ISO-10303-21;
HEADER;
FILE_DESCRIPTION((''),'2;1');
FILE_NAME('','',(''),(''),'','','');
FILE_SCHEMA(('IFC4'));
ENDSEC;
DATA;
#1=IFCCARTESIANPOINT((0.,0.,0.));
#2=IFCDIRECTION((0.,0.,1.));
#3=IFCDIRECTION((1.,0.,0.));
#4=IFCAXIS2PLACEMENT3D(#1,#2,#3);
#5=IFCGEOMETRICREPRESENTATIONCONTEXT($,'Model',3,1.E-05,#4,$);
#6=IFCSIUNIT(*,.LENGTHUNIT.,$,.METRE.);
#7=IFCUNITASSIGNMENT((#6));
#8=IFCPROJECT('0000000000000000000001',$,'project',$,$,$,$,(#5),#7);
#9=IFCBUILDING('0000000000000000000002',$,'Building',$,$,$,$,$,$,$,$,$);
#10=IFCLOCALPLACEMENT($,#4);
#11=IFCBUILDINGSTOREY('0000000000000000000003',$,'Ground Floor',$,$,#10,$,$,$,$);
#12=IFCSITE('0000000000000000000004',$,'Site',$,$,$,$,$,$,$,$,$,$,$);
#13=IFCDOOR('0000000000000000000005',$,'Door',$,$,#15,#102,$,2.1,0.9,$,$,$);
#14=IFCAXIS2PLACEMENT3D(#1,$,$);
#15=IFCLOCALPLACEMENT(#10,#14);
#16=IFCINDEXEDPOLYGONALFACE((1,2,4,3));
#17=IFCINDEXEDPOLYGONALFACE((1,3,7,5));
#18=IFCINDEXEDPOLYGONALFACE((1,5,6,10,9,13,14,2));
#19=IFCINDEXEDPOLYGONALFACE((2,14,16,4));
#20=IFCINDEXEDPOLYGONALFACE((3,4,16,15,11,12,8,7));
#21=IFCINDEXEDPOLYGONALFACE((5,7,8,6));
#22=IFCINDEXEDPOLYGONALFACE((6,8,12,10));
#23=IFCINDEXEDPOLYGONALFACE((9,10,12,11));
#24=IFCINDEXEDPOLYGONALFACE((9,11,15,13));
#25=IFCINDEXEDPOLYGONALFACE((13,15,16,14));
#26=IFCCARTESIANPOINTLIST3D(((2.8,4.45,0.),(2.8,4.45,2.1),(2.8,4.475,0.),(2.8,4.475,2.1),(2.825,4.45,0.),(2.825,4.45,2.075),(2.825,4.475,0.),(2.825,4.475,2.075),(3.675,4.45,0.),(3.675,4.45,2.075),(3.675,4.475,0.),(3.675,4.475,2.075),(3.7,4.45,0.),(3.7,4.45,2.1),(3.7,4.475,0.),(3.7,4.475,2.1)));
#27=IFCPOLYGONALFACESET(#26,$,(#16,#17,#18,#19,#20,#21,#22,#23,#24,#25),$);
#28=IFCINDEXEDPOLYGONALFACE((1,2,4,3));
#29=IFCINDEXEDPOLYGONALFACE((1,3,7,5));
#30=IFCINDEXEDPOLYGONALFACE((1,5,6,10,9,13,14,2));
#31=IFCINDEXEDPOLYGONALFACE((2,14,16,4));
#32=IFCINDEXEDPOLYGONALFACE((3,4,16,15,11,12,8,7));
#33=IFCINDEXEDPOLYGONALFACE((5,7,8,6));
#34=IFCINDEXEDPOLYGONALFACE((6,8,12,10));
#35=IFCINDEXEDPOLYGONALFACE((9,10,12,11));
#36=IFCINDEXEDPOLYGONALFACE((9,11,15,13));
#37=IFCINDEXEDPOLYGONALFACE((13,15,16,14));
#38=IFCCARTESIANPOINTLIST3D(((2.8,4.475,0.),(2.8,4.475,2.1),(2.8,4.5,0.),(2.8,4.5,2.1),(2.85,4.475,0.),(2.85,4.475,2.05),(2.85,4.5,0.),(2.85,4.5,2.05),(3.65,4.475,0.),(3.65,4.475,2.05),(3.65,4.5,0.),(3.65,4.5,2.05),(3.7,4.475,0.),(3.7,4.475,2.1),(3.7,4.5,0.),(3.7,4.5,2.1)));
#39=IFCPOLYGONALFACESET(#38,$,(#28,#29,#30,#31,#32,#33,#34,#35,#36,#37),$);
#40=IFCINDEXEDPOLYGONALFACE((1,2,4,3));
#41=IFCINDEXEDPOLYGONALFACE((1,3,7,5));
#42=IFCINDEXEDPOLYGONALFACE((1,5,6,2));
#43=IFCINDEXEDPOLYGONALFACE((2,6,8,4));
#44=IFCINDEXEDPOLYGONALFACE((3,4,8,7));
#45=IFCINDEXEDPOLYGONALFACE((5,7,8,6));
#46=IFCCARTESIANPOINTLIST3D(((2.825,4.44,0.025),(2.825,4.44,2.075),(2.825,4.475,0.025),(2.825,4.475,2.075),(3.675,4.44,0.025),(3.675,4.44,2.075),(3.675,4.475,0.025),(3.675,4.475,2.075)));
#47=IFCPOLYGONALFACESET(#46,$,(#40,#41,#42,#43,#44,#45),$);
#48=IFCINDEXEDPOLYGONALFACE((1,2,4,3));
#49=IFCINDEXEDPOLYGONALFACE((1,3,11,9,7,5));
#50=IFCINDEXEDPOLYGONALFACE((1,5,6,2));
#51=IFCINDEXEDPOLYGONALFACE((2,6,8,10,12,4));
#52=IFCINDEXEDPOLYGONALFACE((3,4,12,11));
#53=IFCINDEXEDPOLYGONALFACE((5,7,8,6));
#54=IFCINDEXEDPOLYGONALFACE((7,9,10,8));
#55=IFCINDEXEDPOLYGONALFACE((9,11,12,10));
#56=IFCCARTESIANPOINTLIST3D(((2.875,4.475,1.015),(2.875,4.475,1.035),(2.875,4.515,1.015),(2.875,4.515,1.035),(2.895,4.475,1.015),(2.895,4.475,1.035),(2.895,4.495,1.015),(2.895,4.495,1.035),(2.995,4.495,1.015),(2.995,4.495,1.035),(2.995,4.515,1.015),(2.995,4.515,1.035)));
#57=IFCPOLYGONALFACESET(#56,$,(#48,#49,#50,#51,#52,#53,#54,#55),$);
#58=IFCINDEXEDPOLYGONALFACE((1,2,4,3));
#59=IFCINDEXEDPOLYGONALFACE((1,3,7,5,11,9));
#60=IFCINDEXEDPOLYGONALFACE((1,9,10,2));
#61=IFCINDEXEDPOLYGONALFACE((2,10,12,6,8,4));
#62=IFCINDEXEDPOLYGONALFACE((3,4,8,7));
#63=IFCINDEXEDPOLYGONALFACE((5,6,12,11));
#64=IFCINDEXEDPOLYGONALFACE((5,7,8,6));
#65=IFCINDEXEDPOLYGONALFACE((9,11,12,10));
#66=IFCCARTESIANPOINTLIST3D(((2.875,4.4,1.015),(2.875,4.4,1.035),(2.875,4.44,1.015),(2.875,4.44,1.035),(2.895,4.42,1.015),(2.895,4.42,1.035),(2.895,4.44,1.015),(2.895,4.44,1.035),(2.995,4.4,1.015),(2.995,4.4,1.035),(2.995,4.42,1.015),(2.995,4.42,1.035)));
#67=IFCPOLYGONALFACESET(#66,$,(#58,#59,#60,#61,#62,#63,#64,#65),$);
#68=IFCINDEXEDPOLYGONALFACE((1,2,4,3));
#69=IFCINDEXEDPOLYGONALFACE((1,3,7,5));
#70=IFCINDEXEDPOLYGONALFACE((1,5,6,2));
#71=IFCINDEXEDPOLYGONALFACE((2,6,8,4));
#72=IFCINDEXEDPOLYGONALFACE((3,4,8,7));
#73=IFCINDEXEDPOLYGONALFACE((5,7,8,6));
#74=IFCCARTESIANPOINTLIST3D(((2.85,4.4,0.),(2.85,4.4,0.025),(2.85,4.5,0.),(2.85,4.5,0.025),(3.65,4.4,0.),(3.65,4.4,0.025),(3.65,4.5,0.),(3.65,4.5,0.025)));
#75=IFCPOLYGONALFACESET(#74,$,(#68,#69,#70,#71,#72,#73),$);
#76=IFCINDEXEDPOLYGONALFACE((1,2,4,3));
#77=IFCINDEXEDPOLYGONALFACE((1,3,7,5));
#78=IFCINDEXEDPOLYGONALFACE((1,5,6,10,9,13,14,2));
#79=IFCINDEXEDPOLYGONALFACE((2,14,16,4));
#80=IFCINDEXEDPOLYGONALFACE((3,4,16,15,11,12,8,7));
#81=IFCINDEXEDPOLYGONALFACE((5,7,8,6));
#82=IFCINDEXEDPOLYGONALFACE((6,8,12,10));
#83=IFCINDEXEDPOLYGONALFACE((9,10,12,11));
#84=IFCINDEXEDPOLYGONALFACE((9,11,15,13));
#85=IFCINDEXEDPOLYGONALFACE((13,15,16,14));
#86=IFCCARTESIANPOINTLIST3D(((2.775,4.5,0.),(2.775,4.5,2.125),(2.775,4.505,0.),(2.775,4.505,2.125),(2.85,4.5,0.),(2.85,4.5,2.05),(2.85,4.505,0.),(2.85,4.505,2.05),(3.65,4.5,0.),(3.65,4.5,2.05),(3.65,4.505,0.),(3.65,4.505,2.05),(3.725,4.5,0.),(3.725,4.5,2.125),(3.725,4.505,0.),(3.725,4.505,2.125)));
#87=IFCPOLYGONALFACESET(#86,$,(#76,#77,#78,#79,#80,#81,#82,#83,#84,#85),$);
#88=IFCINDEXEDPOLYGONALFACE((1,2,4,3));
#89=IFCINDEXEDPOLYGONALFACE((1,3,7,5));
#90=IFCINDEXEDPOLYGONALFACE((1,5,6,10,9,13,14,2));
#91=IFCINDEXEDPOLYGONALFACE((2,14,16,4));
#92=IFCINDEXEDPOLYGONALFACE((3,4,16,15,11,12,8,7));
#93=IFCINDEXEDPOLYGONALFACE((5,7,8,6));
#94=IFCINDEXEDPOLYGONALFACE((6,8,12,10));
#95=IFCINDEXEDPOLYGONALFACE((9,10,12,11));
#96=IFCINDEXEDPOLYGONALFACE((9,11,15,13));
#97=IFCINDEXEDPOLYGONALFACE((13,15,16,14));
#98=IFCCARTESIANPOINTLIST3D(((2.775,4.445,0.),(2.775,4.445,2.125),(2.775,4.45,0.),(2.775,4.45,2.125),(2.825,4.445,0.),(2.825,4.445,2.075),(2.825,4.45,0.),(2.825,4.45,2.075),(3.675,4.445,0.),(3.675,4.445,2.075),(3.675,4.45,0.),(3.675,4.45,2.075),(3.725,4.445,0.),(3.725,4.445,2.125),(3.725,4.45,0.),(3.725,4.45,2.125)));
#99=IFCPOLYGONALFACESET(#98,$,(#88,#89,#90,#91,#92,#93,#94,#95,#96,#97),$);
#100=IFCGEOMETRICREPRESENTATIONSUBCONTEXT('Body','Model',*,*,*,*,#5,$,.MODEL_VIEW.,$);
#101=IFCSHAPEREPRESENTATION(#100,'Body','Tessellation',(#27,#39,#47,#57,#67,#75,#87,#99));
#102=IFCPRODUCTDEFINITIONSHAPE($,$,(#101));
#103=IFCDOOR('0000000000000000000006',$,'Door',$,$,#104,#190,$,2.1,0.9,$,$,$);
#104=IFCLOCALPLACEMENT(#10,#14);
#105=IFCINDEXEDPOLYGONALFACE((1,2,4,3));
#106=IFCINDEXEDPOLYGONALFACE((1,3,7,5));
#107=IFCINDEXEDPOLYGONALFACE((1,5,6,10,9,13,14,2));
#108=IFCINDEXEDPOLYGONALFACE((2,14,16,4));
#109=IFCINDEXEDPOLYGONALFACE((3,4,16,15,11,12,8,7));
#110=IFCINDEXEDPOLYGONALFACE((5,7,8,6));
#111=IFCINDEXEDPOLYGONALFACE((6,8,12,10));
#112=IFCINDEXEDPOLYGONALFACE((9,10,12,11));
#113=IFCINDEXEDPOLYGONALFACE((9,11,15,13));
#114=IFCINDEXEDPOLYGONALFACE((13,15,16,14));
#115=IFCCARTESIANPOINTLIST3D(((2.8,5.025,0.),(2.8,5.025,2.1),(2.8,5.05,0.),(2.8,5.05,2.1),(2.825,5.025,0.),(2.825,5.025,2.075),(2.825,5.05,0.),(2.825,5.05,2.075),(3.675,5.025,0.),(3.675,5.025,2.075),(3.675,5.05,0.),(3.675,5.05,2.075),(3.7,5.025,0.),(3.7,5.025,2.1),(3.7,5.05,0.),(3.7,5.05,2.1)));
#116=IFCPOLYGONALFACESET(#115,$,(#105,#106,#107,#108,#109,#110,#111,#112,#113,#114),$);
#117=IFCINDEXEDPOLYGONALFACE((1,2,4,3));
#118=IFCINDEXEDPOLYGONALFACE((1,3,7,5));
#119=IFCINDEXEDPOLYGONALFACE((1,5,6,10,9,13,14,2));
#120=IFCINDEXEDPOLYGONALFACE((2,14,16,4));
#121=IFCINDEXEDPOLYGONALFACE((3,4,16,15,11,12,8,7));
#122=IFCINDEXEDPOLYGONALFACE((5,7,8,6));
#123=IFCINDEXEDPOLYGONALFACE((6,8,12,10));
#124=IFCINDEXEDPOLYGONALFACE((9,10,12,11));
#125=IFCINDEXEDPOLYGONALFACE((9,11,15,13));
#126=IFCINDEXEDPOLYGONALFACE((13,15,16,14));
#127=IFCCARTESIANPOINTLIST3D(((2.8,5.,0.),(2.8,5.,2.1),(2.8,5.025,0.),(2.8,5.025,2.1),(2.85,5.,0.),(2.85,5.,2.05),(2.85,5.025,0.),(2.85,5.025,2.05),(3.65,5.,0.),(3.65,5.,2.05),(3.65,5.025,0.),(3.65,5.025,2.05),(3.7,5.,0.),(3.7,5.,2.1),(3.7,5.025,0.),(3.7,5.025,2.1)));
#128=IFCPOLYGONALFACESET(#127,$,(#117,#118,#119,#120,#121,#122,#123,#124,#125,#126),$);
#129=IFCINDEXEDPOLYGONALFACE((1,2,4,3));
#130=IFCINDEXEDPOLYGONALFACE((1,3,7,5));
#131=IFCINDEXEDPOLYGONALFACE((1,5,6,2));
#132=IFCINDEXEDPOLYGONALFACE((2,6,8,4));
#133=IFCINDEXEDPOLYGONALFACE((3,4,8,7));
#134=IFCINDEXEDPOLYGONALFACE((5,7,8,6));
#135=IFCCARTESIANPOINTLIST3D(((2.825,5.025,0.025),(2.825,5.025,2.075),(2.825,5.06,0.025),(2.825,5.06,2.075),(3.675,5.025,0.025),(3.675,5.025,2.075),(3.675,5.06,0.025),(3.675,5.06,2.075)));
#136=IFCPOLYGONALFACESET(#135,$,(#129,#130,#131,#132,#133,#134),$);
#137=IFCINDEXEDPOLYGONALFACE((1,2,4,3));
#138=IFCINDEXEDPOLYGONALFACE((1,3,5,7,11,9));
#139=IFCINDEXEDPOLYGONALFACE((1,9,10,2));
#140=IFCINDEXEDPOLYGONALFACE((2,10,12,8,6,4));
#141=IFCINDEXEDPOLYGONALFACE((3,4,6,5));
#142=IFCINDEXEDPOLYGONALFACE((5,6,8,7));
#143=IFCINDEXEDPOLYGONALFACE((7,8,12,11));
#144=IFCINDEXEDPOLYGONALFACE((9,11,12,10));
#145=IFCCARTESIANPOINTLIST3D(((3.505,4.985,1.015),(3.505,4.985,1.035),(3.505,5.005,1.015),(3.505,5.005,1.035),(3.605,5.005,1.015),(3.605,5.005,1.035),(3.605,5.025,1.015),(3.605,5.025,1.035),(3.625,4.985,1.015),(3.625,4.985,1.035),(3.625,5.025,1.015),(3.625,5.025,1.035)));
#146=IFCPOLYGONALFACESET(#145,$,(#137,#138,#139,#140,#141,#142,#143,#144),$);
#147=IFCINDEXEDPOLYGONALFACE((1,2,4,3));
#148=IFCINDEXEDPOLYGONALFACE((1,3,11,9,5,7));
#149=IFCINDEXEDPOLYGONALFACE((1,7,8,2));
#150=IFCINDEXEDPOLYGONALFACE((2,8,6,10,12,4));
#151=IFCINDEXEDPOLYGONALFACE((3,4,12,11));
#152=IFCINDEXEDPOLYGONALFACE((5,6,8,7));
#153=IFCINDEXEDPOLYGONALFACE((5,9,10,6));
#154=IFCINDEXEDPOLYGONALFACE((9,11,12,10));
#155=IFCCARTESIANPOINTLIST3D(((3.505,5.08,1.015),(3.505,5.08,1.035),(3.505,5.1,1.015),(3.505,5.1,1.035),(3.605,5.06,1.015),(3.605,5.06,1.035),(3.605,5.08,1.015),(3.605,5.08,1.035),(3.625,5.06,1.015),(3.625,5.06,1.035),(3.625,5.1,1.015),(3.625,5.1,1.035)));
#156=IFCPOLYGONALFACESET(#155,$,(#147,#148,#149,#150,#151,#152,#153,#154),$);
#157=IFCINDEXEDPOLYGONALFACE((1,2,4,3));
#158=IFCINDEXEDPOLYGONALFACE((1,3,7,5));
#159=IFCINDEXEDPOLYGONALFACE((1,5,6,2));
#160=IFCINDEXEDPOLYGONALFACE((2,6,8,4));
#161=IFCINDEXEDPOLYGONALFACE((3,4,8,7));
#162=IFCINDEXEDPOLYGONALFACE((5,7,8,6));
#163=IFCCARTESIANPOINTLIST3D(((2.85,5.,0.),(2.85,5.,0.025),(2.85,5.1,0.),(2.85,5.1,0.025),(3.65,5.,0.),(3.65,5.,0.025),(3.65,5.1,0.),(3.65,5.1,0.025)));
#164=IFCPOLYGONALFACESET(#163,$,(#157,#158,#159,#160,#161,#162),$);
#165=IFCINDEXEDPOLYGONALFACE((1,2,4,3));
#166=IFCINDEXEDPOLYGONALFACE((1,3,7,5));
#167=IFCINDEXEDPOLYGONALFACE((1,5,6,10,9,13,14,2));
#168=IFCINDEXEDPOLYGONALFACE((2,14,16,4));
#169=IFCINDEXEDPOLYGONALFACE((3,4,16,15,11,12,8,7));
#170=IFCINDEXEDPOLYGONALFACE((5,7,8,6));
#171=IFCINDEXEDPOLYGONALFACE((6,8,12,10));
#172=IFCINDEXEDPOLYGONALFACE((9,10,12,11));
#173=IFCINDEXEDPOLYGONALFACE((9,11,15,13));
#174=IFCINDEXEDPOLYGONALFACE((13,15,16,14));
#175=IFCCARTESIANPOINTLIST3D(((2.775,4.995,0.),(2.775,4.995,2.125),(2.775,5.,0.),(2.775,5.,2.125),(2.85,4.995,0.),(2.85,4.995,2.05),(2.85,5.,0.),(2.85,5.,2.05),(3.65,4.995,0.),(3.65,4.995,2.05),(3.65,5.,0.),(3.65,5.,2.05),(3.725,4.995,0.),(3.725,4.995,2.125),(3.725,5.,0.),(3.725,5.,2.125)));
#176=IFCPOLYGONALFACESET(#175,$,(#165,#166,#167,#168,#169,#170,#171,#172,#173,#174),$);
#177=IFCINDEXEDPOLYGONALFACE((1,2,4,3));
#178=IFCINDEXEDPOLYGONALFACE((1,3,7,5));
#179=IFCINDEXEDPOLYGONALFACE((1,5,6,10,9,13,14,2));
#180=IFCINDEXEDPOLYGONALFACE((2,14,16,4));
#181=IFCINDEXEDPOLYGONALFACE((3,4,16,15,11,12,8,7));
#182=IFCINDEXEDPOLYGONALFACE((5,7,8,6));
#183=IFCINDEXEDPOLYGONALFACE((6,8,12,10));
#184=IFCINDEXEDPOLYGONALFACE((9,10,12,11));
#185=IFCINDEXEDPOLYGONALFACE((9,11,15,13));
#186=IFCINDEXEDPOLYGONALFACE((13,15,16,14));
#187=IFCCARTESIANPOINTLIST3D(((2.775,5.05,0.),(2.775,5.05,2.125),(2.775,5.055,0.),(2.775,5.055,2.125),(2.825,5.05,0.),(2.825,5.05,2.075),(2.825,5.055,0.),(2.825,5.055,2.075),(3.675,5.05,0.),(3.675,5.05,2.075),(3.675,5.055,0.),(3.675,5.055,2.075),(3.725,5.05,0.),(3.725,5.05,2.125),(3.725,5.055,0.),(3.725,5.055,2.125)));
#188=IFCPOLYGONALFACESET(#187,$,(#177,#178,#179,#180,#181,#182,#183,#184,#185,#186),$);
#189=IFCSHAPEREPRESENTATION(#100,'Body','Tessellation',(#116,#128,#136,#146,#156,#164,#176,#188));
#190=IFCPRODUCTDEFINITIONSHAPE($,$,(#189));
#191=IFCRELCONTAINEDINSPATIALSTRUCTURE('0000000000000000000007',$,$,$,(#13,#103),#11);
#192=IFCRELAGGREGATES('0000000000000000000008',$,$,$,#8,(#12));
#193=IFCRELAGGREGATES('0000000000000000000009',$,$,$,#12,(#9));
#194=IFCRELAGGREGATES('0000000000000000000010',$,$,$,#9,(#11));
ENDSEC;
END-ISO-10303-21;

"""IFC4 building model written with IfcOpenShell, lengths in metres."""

from ifc_helpers import new_model, si_unit, frame, origin_with_axes, place, context, subcontext, project, spatial, line, indexed_curve, outline, extrude, element, save


model = new_model("IFC4")

# Units and contexts
model_context = context("Model", 3, precision=1e-05, world=origin_with_axes())
body_context = subcontext(model_context, "Body", "Model", "MODEL_VIEW")
ifc_project = project(units=[si_unit("LENGTHUNIT", "METRE")], contexts=[model_context])

# Site, building, storey
site = spatial("IfcSite", under=ifc_project, Name="Site")
building = spatial("IfcBuilding", under=site, Name="Building")
storey_placement = place(None, origin_with_axes())
storey = spatial("IfcBuildingStorey", under=building, at=storey_placement, Name="Ground Floor")

# Doors
door_1_placement = place(storey_placement, frame((3.7, 4.5, 0.0), z_axis=(0.0, 0.0, 1.0), x_axis=(-1.0, 0.0, 0.0)))
element("IfcDoor", 1, at=door_1_placement, inside=storey, Name="Door", OverallHeight=2.1, OverallWidth=0.9, context=body_context, shape_type="SweptSolid", body=[
    extrude(outline(indexed_curve([(0.0, 0.0), (0.0, 2.1), (0.9, 2.1), (0.9, 0.0), (0.875, 0.0), (0.875, 2.075), (0.025, 2.075), (0.025, 0.0)], segments=[line(1, 2, 3, 4, 5, 6, 7, 8, 1)])), frame((0.0, 0.025, 0.0), z_axis=(0.0, -1.0, 0.0), x_axis=(1.0, 0.0, 0.0)), (0.0, 0.0, -1.0), 0.025),
    extrude(outline(indexed_curve([(0.0, 0.0), (0.0, 2.1), (0.9, 2.1), (0.9, 0.0), (0.85, 0.0), (0.85, 2.05), (0.05, 2.05), (0.05, 0.0)], segments=[line(1, 2, 3, 4, 5, 6, 7, 8, 1)])), frame((0.0, 0.0, 0.0), z_axis=(0.0, -1.0, 0.0), x_axis=(1.0, 0.0, 0.0)), (0.0, 0.0, -1.0), 0.025),
    extrude(outline(indexed_curve([(0.0, 0.0), (0.85, 0.0), (0.85, 0.035), (0.0, 0.035)], segments=[line(1, 2, 3, 4, 1)])), frame((0.025, 0.025, 0.025), z_axis=(0.0, 0.0, 1.0), x_axis=(1.0, 0.0, 0.0)), (0.0, 0.0, 1.0), 2.05),
    extrude(outline(indexed_curve([(0.0, 0.0), (0.0, -0.04), (-0.12, -0.04), (-0.12, -0.02), (-0.02, -0.02), (-0.02, 0.0)], segments=[line(1, 2, 3, 4, 5, 6, 1)])), frame((0.825, 0.025, 1.015), z_axis=(0.0, 0.0, 1.0), x_axis=(1.0, 0.0, 0.0)), (0.0, 0.0, 1.0), 0.02),
    extrude(outline(indexed_curve([(0.0, 0.0), (0.0, 0.04), (-0.12, 0.04), (-0.12, 0.02), (-0.02, 0.02), (-0.02, 0.0)], segments=[line(1, 2, 3, 4, 5, 6, 1)])), frame((0.825, 0.06, 1.015), z_axis=(0.0, 0.0, 1.0), x_axis=(1.0, 0.0, 0.0)), (0.0, 0.0, 1.0), 0.02),
    extrude(outline(indexed_curve([(0.0, 0.0), (0.8, 0.0), (0.8, 0.1), (0.0, 0.1)], segments=[line(1, 2, 3, 4, 1)])), frame((0.05, 0.0, 0.0), z_axis=(0.0, 0.0, 1.0), x_axis=(1.0, 0.0, 0.0)), (0.0, 0.0, 1.0), 0.025),
    extrude(outline(indexed_curve([(0.0, 0.0), (0.0, 2.125), (0.95, 2.125), (0.95, 0.0), (0.875, 0.0), (0.875, 2.05), (0.075, 2.05), (0.075, 0.0)], segments=[line(1, 2, 3, 4, 5, 6, 7, 8, 1)])), frame((-0.025, -0.005, 0.0), z_axis=(0.0, -1.0, 0.0), x_axis=(1.0, 0.0, 0.0)), (0.0, 0.0, -1.0), 0.005),
    extrude(outline(indexed_curve([(0.0, 0.0), (0.0, 2.125), (0.95, 2.125), (0.95, 0.0), (0.9, 0.0), (0.9, 2.075), (0.05, 2.075), (0.05, 0.0)], segments=[line(1, 2, 3, 4, 5, 6, 7, 8, 1)])), frame((-0.025, 0.05, 0.0), z_axis=(0.0, -1.0, 0.0), x_axis=(1.0, 0.0, 0.0)), (0.0, 0.0, -1.0), 0.005),
])
door_2_placement = place(storey_placement, frame((2.8, 5.0, 0.0), z_axis=(0.0, 0.0, 1.0), x_axis=(1.0, 0.0, 0.0)))
element("IfcDoor", 2, at=door_2_placement, inside=storey, Name="Door", OverallHeight=2.1, OverallWidth=0.9, context=body_context, shape_type="SweptSolid", body=[
    extrude(outline(indexed_curve([(0.0, 0.0), (0.0, 2.1), (0.9, 2.1), (0.9, 0.0), (0.875, 0.0), (0.875, 2.075), (0.025, 2.075), (0.025, 0.0)], segments=[line(1, 2, 3, 4, 5, 6, 7, 8, 1)])), frame((0.0, 0.025, 0.0), z_axis=(0.0, -1.0, 0.0), x_axis=(1.0, 0.0, 0.0)), (0.0, 0.0, -1.0), 0.025),
    extrude(outline(indexed_curve([(0.0, 0.0), (0.0, 2.1), (0.9, 2.1), (0.9, 0.0), (0.85, 0.0), (0.85, 2.05), (0.05, 2.05), (0.05, 0.0)], segments=[line(1, 2, 3, 4, 5, 6, 7, 8, 1)])), frame((0.0, 0.0, 0.0), z_axis=(0.0, -1.0, 0.0), x_axis=(1.0, 0.0, 0.0)), (0.0, 0.0, -1.0), 0.025),
    extrude(outline(indexed_curve([(0.0, 0.0), (0.85, 0.0), (0.85, 0.035), (0.0, 0.035)], segments=[line(1, 2, 3, 4, 1)])), frame((0.025, 0.025, 0.025), z_axis=(0.0, 0.0, 1.0), x_axis=(1.0, 0.0, 0.0)), (0.0, 0.0, 1.0), 2.05),
    extrude(outline(indexed_curve([(0.0, 0.0), (0.0, -0.04), (-0.12, -0.04), (-0.12, -0.02), (-0.02, -0.02), (-0.02, 0.0)], segments=[line(1, 2, 3, 4, 5, 6, 1)])), frame((0.825, 0.025, 1.015), z_axis=(0.0, 0.0, 1.0), x_axis=(1.0, 0.0, 0.0)), (0.0, 0.0, 1.0), 0.02),
    extrude(outline(indexed_curve([(0.0, 0.0), (0.0, 0.04), (-0.12, 0.04), (-0.12, 0.02), (-0.02, 0.02), (-0.02, 0.0)], segments=[line(1, 2, 3, 4, 5, 6, 1)])), frame((0.825, 0.06, 1.015), z_axis=(0.0, 0.0, 1.0), x_axis=(1.0, 0.0, 0.0)), (0.0, 0.0, 1.0), 0.02),
    extrude(outline(indexed_curve([(0.0, 0.0), (0.8, 0.0), (0.8, 0.1), (0.0, 0.1)], segments=[line(1, 2, 3, 4, 1)])), frame((0.05, 0.0, 0.0), z_axis=(0.0, 0.0, 1.0), x_axis=(1.0, 0.0, 0.0)), (0.0, 0.0, 1.0), 0.025),
    extrude(outline(indexed_curve([(0.0, 0.0), (0.0, 2.125), (0.95, 2.125), (0.95, 0.0), (0.875, 0.0), (0.875, 2.05), (0.075, 2.05), (0.075, 0.0)], segments=[line(1, 2, 3, 4, 5, 6, 7, 8, 1)])), frame((-0.025, -0.005, 0.0), z_axis=(0.0, -1.0, 0.0), x_axis=(1.0, 0.0, 0.0)), (0.0, 0.0, -1.0), 0.005),
    extrude(outline(indexed_curve([(0.0, 0.0), (0.0, 2.125), (0.95, 2.125), (0.95, 0.0), (0.9, 0.0), (0.9, 2.075), (0.05, 2.075), (0.05, 0.0)], segments=[line(1, 2, 3, 4, 5, 6, 7, 8, 1)])), frame((-0.025, 0.05, 0.0), z_axis=(0.0, -1.0, 0.0), x_axis=(1.0, 0.0, 0.0)), (0.0, 0.0, -1.0), 0.005),
])

save(model, "model.ifc")
